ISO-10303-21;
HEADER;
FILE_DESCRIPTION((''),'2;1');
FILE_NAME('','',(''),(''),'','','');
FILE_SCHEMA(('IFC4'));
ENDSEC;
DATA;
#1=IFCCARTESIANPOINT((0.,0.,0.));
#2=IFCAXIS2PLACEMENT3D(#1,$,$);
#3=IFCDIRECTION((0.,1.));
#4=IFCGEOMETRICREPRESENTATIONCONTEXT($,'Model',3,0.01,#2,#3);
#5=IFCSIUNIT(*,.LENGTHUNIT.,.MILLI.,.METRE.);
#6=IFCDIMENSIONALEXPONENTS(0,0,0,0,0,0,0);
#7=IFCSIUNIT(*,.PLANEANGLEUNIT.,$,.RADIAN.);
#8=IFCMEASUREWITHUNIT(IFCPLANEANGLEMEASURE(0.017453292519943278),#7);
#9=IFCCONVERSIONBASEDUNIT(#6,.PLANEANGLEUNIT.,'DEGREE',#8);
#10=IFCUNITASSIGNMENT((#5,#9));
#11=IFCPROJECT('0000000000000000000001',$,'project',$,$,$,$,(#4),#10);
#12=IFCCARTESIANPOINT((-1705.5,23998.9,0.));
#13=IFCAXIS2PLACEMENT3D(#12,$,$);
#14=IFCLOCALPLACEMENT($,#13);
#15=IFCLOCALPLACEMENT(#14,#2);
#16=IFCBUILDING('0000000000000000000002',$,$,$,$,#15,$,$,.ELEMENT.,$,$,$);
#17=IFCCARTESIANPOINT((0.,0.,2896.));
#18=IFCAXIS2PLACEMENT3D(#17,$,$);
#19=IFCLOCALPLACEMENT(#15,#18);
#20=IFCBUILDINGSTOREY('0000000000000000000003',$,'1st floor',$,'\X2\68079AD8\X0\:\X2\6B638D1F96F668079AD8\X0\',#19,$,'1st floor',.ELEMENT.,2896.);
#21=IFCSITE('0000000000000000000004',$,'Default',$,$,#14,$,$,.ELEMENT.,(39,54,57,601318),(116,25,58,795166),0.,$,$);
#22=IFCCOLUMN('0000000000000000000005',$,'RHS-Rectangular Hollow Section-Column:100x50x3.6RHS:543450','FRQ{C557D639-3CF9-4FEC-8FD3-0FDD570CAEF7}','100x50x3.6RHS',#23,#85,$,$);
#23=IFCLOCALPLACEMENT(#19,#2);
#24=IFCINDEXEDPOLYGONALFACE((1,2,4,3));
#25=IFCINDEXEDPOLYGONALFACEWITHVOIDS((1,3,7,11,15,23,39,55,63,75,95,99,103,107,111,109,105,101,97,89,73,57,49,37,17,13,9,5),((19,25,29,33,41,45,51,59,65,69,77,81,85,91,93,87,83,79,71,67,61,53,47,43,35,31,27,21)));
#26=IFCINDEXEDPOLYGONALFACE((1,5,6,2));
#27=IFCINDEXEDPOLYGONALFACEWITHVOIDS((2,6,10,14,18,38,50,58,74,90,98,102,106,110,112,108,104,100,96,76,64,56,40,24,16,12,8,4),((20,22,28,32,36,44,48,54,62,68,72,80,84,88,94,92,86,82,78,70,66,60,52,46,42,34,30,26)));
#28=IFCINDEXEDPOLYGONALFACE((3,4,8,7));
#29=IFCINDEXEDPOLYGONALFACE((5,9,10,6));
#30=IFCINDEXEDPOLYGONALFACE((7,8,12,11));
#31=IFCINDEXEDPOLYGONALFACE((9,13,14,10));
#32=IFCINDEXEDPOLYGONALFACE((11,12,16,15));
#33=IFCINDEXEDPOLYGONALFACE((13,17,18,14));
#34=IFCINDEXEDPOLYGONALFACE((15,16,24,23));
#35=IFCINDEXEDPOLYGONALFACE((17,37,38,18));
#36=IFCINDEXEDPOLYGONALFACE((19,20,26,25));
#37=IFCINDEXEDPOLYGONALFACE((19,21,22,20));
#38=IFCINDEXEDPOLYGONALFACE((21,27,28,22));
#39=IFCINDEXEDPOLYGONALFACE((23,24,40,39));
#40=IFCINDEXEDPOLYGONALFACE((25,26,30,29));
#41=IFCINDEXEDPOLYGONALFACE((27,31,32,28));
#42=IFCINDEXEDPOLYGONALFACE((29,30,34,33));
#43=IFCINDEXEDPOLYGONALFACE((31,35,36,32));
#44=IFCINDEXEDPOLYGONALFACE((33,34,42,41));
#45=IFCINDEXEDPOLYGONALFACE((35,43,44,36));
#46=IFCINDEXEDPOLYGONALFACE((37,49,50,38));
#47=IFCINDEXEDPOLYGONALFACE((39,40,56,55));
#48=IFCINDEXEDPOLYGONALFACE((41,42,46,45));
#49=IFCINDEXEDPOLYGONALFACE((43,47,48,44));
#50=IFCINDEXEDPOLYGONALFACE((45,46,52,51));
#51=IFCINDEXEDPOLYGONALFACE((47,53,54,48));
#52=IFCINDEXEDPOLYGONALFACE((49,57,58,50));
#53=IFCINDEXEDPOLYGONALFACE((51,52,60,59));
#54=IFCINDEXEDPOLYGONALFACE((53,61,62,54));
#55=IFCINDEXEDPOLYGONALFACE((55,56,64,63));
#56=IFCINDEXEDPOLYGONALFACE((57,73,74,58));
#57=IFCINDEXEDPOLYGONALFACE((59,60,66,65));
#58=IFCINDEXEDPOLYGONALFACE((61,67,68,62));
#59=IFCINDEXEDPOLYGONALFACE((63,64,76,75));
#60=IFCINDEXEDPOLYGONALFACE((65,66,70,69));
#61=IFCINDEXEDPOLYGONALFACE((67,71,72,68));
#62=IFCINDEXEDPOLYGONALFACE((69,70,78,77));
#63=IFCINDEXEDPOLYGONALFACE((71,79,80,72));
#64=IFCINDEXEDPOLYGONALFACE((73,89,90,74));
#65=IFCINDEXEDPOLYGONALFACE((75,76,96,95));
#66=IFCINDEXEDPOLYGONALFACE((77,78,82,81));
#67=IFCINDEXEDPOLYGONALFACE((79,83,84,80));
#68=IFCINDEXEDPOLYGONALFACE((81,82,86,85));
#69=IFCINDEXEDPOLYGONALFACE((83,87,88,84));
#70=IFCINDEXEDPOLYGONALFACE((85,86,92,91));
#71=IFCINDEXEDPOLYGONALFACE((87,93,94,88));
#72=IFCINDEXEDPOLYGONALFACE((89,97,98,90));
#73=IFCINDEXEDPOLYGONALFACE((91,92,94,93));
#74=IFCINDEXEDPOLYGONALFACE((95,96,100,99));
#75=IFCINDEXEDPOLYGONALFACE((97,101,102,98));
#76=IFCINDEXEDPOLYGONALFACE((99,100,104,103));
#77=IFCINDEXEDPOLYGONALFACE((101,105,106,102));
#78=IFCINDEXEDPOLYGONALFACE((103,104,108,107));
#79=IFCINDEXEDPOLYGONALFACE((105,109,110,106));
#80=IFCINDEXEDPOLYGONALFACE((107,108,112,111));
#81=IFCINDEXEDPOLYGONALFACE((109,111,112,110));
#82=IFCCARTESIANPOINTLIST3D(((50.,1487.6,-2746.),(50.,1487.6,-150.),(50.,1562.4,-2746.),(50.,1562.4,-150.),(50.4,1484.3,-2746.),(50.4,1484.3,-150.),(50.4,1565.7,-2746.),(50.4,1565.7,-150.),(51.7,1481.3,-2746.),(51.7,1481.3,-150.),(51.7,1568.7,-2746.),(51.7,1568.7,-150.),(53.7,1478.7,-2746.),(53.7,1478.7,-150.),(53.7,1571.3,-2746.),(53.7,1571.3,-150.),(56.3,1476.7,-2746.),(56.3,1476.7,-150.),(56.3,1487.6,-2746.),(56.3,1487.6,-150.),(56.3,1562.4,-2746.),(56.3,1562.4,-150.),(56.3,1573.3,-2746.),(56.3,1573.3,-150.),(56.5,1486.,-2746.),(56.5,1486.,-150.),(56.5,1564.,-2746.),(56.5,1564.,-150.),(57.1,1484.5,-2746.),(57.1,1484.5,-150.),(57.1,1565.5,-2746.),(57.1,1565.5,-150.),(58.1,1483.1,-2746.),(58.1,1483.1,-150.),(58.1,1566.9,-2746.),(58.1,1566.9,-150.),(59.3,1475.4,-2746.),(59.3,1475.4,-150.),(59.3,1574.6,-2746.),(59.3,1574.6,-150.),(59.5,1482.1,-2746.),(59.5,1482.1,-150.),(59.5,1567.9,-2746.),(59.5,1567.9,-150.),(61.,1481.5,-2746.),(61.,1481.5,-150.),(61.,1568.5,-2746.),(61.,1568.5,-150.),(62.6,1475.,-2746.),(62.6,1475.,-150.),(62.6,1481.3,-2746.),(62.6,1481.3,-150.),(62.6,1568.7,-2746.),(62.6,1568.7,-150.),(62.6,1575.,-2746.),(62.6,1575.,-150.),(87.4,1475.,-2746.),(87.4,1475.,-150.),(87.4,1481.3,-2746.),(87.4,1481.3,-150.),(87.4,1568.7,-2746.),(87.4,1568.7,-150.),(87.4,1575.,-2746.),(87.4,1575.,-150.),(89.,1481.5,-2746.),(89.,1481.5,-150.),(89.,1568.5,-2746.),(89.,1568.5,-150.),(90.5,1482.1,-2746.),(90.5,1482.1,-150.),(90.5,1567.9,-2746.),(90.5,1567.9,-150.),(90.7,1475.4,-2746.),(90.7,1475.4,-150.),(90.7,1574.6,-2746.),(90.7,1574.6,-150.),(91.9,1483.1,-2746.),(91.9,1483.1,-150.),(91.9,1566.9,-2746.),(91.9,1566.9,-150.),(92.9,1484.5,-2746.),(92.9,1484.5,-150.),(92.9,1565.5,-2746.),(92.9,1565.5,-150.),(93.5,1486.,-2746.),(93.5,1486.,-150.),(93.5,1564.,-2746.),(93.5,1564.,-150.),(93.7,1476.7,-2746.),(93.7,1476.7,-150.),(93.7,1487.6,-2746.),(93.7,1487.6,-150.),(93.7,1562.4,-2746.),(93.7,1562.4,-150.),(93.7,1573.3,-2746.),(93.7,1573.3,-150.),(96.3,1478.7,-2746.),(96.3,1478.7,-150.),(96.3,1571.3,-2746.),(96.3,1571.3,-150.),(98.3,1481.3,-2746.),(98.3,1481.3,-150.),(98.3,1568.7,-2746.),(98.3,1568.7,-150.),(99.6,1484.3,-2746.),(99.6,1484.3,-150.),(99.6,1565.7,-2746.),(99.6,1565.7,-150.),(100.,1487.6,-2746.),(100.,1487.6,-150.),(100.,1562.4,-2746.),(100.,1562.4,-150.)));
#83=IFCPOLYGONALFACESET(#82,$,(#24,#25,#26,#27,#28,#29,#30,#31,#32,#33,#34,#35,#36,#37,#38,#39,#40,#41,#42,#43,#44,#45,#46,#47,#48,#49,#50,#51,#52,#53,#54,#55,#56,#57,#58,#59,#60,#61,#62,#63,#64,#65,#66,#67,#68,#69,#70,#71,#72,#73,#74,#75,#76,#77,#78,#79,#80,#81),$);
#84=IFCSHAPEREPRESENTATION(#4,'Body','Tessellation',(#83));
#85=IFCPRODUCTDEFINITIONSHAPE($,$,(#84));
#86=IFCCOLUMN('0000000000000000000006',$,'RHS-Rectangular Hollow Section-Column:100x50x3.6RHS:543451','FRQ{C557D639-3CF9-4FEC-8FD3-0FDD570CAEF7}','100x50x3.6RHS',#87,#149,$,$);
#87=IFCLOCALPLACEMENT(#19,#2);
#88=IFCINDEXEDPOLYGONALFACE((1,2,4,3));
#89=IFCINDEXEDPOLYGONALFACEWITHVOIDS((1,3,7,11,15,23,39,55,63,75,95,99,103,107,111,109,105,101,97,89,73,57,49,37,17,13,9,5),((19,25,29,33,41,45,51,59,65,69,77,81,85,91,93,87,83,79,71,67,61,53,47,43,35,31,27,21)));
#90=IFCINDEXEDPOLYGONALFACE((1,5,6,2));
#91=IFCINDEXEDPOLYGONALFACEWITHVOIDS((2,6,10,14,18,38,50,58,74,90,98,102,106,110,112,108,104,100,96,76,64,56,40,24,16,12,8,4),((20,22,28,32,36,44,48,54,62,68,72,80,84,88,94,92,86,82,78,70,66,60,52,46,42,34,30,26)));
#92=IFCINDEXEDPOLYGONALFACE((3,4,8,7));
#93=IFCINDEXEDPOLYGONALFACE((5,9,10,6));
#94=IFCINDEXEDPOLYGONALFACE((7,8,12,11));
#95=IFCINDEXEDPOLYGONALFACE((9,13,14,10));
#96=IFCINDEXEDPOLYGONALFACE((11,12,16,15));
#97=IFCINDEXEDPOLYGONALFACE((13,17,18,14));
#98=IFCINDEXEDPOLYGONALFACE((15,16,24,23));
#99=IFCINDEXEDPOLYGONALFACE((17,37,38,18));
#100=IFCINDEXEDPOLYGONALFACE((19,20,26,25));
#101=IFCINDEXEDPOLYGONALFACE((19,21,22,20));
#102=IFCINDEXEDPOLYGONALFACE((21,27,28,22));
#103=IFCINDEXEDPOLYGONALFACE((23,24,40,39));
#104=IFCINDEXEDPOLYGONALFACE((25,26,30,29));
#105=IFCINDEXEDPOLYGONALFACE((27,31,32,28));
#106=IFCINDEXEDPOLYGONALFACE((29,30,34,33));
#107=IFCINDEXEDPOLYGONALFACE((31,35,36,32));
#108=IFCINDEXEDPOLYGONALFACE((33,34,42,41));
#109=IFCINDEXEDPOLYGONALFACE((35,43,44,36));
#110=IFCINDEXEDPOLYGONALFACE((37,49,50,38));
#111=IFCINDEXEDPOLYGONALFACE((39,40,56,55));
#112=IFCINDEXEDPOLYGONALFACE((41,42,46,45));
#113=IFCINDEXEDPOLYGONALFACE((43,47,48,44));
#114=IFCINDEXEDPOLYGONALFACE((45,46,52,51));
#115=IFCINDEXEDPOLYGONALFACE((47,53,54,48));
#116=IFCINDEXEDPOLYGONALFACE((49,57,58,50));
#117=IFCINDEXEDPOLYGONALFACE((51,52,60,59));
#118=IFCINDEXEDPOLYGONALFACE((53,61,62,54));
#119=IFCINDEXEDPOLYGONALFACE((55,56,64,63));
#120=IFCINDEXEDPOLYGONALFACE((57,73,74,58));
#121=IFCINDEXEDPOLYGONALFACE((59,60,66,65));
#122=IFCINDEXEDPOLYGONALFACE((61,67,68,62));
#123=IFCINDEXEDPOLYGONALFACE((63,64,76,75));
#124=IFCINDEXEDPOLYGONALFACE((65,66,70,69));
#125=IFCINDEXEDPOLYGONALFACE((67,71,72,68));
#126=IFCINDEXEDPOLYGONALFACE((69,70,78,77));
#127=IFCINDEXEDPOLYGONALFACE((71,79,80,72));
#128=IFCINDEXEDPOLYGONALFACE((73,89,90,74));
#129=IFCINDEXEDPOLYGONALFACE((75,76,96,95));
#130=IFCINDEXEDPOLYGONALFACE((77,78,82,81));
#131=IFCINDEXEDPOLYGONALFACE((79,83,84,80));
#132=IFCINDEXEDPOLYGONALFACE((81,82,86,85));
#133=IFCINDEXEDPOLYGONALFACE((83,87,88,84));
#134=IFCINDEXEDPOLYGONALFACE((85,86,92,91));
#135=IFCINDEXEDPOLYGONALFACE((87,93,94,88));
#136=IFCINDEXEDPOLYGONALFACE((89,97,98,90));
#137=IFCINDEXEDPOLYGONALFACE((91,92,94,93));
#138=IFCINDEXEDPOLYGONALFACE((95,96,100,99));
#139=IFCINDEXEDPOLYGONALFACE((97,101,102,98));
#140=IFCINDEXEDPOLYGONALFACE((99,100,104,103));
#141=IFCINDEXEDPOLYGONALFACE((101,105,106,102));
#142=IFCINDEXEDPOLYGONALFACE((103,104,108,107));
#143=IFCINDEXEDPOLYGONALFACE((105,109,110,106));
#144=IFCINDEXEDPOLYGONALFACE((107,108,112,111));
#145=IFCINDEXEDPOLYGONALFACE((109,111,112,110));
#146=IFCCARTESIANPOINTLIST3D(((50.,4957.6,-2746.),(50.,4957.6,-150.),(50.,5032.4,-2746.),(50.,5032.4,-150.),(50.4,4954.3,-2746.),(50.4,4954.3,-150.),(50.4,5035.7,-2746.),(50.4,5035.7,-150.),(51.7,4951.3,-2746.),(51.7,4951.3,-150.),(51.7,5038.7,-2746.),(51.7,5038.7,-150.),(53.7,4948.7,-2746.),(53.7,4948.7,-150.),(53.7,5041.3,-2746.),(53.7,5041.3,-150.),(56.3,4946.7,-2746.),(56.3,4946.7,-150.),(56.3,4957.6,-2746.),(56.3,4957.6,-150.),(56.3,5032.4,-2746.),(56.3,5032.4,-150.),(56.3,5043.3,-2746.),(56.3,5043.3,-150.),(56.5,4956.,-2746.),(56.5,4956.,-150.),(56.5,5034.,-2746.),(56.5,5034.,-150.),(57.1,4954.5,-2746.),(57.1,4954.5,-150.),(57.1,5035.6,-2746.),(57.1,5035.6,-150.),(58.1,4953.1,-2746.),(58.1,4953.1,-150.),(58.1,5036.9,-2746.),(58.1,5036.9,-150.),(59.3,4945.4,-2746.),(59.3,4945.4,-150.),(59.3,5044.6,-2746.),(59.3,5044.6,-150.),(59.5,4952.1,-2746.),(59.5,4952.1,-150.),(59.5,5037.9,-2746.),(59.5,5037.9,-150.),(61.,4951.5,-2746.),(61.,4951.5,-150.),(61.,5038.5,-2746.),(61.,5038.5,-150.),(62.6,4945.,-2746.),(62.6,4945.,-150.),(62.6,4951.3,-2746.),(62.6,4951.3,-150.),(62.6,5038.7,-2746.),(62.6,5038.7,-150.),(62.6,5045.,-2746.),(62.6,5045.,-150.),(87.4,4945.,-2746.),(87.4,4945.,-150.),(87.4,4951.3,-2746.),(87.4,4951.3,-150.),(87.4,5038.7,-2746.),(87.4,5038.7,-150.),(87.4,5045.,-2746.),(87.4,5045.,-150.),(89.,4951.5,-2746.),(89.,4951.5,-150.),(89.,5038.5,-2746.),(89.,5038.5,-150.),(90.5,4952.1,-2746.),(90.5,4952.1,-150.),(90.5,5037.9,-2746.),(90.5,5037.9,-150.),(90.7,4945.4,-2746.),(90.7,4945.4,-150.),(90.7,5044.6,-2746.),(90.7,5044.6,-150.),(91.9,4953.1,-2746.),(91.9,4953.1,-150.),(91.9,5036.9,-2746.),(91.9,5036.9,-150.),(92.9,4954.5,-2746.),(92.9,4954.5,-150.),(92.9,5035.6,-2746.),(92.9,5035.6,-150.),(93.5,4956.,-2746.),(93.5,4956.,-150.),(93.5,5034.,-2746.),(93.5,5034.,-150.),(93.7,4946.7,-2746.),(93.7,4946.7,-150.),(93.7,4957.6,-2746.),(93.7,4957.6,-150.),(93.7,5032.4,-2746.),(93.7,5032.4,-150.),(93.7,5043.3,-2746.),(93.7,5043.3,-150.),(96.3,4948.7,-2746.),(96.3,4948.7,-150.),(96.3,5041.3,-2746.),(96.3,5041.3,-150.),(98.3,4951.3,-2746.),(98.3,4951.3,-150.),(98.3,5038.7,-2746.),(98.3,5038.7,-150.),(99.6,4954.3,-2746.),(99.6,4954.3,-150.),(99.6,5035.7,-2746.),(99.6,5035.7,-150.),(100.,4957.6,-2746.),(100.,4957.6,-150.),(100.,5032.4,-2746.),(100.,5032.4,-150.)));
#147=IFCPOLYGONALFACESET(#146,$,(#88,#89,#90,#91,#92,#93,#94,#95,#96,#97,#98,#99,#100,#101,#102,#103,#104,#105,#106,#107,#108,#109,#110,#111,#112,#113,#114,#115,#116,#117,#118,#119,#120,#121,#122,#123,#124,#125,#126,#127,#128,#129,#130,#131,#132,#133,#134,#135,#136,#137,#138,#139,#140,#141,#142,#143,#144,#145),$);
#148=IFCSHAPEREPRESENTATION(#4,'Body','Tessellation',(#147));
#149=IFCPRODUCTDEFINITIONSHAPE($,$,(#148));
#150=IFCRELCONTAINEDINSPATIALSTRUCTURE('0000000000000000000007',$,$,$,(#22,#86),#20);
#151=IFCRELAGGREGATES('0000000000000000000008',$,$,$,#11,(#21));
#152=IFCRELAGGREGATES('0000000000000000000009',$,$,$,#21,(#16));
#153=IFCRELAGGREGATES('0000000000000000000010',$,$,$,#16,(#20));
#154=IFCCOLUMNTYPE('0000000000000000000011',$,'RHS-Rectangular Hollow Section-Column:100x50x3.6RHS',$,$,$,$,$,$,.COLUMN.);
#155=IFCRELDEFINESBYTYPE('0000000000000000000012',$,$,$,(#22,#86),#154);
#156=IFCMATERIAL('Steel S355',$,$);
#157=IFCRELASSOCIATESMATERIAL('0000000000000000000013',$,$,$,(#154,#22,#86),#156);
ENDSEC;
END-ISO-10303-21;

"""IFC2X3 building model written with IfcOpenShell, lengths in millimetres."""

from ifc_helpers import new_model, entity, si_unit, converted_unit, direction, frame, origin, origin_2d, place, context, project, spatial, hollow_rectangle, extrude, clip, halfspace, material, type_object, element, save


model = new_model("IFC2X3")

# Units and contexts
model_context = context("Model", 3, precision=0.01, world=origin(), true_north=direction((0.0, 1.0)))
ifc_project = project(units=[si_unit("LENGTHUNIT", "METRE", prefix="MILLI"), converted_unit("PLANEANGLEUNIT", "DEGREE", entity("IfcPlaneAngleMeasure", 0.017453292519943278), si_unit("PLANEANGLEUNIT", "RADIAN"), dimensions=[0, 0, 0, 0, 0, 0, 0])], contexts=[model_context])

# Site, building, storey
site_placement = place(None, frame((-1705.5, 23998.9, 0.0)))
site = spatial("IfcSite", under=ifc_project, at=site_placement, Name="Default", CompositionType="ELEMENT", RefLatitude=(39, 54, 57, 601318), RefLongitude=(116, 25, 58, 795166), RefElevation=0.0)
building_placement = place(site_placement, origin())
building = spatial("IfcBuilding", under=site, at=building_placement, CompositionType="ELEMENT")
storey_placement = place(building_placement, frame((0.0, 0.0, 2896.0)))
storey = spatial("IfcBuildingStorey", under=building, at=storey_placement, Name="1st floor", ObjectType="标高:正负零标高", LongName="1st floor", CompositionType="ELEMENT", Elevation=2896.0)

# Columns
ifc_material_1 = material(Name="Steel S355")
column_type_1 = type_object("IfcColumnType", Name="RHS-Rectangular Hollow Section-Column:100x50x3.6RHS", PredefinedType="COLUMN", material=ifc_material_1)
column_1_placement = place(storey_placement, frame((75.0, 1525.0, -150.0), z_axis=(0.0, 0.0, 1.0), x_axis=(-1.0, 0.0, 0.0)))
element("IfcColumn", 1, at=column_1_placement, inside=storey, type_object=column_type_1, material=ifc_material_1, Name="RHS-Rectangular Hollow Section-Column:100x50x3.6RHS:543450", Description="FRQ{C557D639-3CF9-4FEC-8FD3-0FDD570CAEF7}", ObjectType="100x50x3.6RHS", context=model_context, shape_type="Clipping", body=[
    clip(extrude(hollow_rectangle(XDim=50.0, YDim=100.0, WallThickness=6.3, InnerFilletRadius=6.3, OuterFilletRadius=12.6, at=origin_2d()), origin(), (0.0, 0.0, -1.0), 2651.9), halfspace(frame((75.0, 1525.0, -2596.0), z_axis=(0.0, 0.0, 1.0), x_axis=(-1.0, 0.0, 0.0)), True)),
])
column_2_placement = place(storey_placement, frame((75.0, 4995.0, -150.0), z_axis=(0.0, 0.0, 1.0), x_axis=(-1.0, 0.0, 0.0)))
element("IfcColumn", 2, at=column_2_placement, inside=storey, type_object=column_type_1, material=ifc_material_1, Name="RHS-Rectangular Hollow Section-Column:100x50x3.6RHS:543451", Description="FRQ{C557D639-3CF9-4FEC-8FD3-0FDD570CAEF7}", ObjectType="100x50x3.6RHS", context=model_context, shape_type="Clipping", body=[
    clip(extrude(hollow_rectangle(XDim=50.0, YDim=100.0, WallThickness=6.3, InnerFilletRadius=6.3, OuterFilletRadius=12.6, at=origin_2d()), origin(), (0.0, 0.0, -1.0), 2651.9), halfspace(frame((75.0, 4995.0, -2596.0), z_axis=(0.0, 0.0, 1.0), x_axis=(-1.0, 0.0, 0.0)), True)),
])

save(model, "model.ifc")
